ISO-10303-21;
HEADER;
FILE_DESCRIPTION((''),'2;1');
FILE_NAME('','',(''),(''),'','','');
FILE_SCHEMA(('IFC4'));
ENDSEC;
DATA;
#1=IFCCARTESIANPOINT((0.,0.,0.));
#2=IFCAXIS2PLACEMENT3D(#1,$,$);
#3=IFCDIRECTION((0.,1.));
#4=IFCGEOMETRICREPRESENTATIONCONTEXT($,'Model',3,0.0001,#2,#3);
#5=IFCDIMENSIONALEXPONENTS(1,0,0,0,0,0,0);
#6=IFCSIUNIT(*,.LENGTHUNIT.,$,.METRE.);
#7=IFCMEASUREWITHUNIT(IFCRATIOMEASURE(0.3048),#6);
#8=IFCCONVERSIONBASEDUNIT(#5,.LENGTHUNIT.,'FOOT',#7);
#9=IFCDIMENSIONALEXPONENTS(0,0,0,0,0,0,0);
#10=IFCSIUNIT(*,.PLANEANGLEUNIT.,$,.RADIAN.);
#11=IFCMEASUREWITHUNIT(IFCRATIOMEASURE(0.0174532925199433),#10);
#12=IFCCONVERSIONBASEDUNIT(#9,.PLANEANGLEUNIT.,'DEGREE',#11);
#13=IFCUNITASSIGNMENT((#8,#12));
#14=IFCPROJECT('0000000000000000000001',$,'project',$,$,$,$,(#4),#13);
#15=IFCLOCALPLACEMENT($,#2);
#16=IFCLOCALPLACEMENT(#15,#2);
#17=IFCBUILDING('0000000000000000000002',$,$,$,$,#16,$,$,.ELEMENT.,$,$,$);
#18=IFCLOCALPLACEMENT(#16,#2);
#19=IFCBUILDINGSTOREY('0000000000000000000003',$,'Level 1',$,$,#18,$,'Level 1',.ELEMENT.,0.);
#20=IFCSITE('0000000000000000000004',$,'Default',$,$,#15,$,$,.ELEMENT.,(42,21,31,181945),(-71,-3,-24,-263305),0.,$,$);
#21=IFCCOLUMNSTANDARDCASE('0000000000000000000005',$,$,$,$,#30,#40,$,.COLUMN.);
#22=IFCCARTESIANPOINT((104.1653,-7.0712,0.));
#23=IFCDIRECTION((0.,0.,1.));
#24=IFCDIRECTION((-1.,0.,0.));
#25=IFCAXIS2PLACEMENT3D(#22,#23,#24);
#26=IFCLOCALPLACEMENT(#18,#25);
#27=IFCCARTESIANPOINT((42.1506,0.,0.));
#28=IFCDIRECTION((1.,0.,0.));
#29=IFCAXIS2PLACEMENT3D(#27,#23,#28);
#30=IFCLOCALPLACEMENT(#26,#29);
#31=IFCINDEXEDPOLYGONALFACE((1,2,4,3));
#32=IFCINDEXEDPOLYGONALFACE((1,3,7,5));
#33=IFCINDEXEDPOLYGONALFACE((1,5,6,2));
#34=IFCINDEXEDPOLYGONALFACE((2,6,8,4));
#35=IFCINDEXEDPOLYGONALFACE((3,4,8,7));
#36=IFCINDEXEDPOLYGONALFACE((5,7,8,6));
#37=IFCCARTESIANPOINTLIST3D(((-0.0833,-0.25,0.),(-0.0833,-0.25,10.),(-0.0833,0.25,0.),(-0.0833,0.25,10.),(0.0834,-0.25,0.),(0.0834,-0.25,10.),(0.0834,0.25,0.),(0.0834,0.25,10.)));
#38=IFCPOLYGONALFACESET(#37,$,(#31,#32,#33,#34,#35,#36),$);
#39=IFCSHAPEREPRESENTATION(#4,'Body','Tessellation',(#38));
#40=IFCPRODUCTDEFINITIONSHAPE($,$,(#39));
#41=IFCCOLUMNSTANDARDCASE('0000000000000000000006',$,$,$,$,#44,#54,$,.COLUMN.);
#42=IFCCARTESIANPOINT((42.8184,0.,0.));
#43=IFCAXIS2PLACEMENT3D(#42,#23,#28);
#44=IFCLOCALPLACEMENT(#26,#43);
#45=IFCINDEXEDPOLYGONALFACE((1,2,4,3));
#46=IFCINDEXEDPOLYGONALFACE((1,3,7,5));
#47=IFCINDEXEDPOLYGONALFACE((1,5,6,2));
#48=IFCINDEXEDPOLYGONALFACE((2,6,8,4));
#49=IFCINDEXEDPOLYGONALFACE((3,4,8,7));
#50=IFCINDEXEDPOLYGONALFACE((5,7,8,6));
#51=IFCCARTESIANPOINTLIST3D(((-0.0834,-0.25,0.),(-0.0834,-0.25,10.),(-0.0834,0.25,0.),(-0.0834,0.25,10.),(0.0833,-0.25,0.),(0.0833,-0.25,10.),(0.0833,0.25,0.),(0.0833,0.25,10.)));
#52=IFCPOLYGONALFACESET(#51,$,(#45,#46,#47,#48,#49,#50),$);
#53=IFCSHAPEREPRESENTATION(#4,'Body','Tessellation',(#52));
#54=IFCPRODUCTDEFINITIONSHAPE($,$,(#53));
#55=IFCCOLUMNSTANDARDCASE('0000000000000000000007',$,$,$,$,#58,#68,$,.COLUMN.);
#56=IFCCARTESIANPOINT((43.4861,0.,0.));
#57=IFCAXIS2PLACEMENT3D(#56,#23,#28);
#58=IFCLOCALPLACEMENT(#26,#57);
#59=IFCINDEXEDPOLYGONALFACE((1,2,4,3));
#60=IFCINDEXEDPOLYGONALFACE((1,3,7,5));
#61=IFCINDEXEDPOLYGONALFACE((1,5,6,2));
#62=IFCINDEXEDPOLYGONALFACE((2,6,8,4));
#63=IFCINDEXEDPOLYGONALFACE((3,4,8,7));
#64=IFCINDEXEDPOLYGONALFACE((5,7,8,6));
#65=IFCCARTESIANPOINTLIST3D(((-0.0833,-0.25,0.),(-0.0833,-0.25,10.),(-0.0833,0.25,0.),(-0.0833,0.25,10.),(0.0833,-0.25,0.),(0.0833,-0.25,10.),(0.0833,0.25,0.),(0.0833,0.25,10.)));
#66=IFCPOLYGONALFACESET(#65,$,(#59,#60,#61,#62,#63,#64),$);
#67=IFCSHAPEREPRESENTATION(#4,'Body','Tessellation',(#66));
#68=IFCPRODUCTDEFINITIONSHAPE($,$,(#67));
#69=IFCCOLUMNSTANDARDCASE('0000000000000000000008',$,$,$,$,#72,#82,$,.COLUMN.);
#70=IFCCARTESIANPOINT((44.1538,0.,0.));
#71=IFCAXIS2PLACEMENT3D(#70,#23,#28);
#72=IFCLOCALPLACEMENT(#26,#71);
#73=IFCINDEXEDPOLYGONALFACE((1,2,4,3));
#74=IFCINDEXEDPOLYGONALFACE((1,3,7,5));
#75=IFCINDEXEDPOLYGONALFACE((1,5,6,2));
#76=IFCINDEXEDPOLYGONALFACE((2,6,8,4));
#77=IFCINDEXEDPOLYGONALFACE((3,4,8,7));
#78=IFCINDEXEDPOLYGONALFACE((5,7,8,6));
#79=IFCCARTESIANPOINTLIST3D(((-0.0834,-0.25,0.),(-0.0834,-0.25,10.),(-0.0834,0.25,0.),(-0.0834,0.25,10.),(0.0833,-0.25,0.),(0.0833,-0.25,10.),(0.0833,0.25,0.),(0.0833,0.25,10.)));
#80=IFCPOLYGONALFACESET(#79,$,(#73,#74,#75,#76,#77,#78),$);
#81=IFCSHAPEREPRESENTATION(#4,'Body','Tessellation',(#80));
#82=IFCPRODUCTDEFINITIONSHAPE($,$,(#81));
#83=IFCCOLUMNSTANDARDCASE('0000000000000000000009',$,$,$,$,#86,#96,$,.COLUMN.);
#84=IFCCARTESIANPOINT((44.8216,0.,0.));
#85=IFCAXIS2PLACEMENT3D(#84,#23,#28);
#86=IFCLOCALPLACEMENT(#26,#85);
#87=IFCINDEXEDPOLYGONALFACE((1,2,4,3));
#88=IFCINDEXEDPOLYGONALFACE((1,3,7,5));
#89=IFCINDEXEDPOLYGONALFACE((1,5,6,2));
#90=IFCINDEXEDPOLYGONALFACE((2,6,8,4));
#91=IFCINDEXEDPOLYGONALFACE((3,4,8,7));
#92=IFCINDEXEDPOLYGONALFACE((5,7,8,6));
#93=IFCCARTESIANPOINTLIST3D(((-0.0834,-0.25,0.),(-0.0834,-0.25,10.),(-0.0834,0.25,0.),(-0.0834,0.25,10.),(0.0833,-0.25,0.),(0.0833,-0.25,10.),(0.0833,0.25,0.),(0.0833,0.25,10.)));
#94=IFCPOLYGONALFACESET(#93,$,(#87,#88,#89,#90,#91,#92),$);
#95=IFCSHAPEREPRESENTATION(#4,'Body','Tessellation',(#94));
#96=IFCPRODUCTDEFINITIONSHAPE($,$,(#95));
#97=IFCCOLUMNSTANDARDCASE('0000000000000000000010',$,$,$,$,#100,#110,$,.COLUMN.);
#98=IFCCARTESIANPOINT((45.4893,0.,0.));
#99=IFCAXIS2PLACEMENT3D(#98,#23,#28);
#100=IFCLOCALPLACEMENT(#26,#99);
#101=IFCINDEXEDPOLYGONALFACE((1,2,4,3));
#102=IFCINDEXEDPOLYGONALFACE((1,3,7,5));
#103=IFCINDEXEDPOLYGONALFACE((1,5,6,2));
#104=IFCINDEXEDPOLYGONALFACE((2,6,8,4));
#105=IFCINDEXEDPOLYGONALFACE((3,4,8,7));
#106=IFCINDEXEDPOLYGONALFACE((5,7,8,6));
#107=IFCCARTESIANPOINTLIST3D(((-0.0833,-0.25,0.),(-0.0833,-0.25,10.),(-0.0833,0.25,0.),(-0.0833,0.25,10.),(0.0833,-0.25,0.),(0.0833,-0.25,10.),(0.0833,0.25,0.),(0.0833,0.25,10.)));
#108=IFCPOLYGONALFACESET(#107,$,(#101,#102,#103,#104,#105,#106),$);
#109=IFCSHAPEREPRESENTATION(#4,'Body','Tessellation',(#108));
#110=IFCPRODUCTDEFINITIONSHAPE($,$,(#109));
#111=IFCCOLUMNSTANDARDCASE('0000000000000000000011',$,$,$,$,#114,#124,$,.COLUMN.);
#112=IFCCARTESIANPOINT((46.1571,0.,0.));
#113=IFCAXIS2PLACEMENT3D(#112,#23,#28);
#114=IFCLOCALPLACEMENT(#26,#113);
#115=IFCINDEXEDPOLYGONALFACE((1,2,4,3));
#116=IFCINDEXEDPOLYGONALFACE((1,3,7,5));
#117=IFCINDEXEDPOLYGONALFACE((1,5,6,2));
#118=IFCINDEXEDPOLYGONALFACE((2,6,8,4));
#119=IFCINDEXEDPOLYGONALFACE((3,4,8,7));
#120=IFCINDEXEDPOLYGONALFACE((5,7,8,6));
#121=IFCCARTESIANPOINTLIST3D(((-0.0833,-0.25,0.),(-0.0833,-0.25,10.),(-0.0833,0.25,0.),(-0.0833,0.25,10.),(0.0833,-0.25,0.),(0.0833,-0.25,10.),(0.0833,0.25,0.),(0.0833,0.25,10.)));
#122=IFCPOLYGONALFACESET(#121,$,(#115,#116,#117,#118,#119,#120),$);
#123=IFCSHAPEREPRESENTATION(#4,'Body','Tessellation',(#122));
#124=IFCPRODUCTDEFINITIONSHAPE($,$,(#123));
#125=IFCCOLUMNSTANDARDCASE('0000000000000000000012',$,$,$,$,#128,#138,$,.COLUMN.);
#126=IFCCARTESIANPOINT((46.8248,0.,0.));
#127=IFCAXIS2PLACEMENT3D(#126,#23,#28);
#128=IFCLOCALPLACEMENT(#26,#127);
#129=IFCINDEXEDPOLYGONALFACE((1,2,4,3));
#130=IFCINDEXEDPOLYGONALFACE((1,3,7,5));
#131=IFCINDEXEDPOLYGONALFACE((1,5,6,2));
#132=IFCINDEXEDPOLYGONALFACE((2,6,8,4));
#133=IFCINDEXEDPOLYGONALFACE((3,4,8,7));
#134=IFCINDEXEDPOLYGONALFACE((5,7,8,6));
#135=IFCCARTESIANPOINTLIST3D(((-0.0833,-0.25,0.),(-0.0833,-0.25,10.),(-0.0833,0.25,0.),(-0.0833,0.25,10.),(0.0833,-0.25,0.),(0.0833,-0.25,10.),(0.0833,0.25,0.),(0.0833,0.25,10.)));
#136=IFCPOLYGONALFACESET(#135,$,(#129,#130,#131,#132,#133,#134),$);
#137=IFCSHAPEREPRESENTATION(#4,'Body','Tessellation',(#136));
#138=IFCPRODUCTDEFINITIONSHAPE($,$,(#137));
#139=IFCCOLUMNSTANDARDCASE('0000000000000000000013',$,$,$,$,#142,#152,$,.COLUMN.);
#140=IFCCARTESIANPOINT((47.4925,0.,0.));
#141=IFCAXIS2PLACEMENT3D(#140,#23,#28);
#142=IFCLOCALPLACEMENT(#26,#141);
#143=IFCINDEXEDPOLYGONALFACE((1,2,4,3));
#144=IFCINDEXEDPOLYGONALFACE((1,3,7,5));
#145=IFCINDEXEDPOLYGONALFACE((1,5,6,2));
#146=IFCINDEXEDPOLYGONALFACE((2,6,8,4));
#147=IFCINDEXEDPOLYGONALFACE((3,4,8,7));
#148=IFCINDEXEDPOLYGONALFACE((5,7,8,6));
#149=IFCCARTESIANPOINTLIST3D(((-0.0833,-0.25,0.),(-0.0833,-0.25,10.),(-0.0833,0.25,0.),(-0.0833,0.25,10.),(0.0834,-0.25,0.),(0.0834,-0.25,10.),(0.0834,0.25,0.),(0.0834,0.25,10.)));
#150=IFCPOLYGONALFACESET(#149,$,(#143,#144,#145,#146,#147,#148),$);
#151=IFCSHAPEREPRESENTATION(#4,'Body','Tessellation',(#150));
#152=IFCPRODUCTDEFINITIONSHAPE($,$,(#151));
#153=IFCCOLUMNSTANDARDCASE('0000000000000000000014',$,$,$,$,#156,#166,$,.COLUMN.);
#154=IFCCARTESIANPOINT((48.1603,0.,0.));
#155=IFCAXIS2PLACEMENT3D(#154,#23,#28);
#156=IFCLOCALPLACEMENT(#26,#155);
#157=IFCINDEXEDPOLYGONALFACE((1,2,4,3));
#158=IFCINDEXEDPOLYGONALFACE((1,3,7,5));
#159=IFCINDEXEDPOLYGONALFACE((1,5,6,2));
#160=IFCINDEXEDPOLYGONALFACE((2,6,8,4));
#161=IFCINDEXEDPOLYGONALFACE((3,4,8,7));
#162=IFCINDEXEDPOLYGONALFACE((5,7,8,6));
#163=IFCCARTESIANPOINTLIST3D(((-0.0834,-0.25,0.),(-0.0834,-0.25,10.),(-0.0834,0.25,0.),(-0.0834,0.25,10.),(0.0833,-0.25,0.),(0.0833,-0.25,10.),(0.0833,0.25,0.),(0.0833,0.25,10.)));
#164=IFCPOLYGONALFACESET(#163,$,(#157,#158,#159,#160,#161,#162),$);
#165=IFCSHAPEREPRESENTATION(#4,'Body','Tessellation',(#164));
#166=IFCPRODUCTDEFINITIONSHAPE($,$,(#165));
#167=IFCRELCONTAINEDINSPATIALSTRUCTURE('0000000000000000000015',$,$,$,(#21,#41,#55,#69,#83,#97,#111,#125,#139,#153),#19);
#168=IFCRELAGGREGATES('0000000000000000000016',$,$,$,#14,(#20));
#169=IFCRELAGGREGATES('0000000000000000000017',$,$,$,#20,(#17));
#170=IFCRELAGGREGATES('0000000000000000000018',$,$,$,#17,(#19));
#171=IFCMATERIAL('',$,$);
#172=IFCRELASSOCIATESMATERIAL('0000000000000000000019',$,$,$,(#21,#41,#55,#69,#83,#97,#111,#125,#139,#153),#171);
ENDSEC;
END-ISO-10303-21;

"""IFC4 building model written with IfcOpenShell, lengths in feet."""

from ifc_helpers import new_model, entity, si_unit, converted_unit, direction, frame, origin, place, context, project, spatial, rectangle, extrude, material, element, save


model = new_model("IFC4")

# Units and contexts
model_context = context("Model", 3, precision=0.0001, world=origin(), true_north=direction((0.0, 1.0)))
ifc_project = project(units=[converted_unit("LENGTHUNIT", "FOOT", entity("IfcRatioMeasure", 0.3048), si_unit("LENGTHUNIT", "METRE"), dimensions=[1, 0, 0, 0, 0, 0, 0]), converted_unit("PLANEANGLEUNIT", "DEGREE", entity("IfcRatioMeasure", 0.0174532925199433), si_unit("PLANEANGLEUNIT", "RADIAN"), dimensions=[0, 0, 0, 0, 0, 0, 0])], contexts=[model_context])

# Site, building, storey
site_placement = place(None, origin())
site = spatial("IfcSite", under=ifc_project, at=site_placement, Name="Default", CompositionType="ELEMENT", RefLatitude=(42, 21, 31, 181945), RefLongitude=(-71, -3, -24, -263305), RefElevation=0.0)
building_placement = place(site_placement, origin())
building = spatial("IfcBuilding", under=site, at=building_placement, CompositionType="ELEMENT")
storey_placement = place(building_placement, origin())
storey = spatial("IfcBuildingStorey", under=building, at=storey_placement, Name="Level 1", LongName="Level 1", CompositionType="ELEMENT", Elevation=0.0)

# Columns
ifc_material = material(Name="")
placement = place(storey_placement, frame((104.1653, -7.0712, 0.0), z_axis=(0.0, 0.0, 1.0), x_axis=(-1.0, 0.0, 0.0)))
for number, where, z_axis, x_axis in (
    (1, (42.1506, 0.0, 0.0), (0.0, 0.0, 1.0), (1.0, 0.0, 0.0)),
    (2, (42.8184, 0.0, 0.0), (0.0, 0.0, 1.0), (1.0, 0.0, 0.0)),
    (3, (43.4861, 0.0, 0.0), (0.0, 0.0, 1.0), (1.0, 0.0, 0.0)),
    (4, (44.1538, 0.0, 0.0), (0.0, 0.0, 1.0), (1.0, 0.0, 0.0)),
    (5, (44.8216, 0.0, 0.0), (0.0, 0.0, 1.0), (1.0, 0.0, 0.0)),
    (6, (45.4893, 0.0, 0.0), (0.0, 0.0, 1.0), (1.0, 0.0, 0.0)),
    (7, (46.1571, 0.0, 0.0), (0.0, 0.0, 1.0), (1.0, 0.0, 0.0)),
    (8, (46.8248, 0.0, 0.0), (0.0, 0.0, 1.0), (1.0, 0.0, 0.0)),
    (9, (47.4925, 0.0, 0.0), (0.0, 0.0, 1.0), (1.0, 0.0, 0.0)),
    (10, (48.1603, 0.0, 0.0), (0.0, 0.0, 1.0), (1.0, 0.0, 0.0)),
):
    element("IfcColumnStandardCase", number, at=place(placement, frame(where, z_axis=z_axis, x_axis=x_axis)), inside=storey, material=ifc_material, PredefinedType="COLUMN", context=model_context, shape_type="SweptSolid", body=[
        extrude(rectangle(XDim=0.1667, YDim=0.5), origin(), (0.0, 0.0, 1.0), 10.0),
    ])

save(model, "model.ifc")
